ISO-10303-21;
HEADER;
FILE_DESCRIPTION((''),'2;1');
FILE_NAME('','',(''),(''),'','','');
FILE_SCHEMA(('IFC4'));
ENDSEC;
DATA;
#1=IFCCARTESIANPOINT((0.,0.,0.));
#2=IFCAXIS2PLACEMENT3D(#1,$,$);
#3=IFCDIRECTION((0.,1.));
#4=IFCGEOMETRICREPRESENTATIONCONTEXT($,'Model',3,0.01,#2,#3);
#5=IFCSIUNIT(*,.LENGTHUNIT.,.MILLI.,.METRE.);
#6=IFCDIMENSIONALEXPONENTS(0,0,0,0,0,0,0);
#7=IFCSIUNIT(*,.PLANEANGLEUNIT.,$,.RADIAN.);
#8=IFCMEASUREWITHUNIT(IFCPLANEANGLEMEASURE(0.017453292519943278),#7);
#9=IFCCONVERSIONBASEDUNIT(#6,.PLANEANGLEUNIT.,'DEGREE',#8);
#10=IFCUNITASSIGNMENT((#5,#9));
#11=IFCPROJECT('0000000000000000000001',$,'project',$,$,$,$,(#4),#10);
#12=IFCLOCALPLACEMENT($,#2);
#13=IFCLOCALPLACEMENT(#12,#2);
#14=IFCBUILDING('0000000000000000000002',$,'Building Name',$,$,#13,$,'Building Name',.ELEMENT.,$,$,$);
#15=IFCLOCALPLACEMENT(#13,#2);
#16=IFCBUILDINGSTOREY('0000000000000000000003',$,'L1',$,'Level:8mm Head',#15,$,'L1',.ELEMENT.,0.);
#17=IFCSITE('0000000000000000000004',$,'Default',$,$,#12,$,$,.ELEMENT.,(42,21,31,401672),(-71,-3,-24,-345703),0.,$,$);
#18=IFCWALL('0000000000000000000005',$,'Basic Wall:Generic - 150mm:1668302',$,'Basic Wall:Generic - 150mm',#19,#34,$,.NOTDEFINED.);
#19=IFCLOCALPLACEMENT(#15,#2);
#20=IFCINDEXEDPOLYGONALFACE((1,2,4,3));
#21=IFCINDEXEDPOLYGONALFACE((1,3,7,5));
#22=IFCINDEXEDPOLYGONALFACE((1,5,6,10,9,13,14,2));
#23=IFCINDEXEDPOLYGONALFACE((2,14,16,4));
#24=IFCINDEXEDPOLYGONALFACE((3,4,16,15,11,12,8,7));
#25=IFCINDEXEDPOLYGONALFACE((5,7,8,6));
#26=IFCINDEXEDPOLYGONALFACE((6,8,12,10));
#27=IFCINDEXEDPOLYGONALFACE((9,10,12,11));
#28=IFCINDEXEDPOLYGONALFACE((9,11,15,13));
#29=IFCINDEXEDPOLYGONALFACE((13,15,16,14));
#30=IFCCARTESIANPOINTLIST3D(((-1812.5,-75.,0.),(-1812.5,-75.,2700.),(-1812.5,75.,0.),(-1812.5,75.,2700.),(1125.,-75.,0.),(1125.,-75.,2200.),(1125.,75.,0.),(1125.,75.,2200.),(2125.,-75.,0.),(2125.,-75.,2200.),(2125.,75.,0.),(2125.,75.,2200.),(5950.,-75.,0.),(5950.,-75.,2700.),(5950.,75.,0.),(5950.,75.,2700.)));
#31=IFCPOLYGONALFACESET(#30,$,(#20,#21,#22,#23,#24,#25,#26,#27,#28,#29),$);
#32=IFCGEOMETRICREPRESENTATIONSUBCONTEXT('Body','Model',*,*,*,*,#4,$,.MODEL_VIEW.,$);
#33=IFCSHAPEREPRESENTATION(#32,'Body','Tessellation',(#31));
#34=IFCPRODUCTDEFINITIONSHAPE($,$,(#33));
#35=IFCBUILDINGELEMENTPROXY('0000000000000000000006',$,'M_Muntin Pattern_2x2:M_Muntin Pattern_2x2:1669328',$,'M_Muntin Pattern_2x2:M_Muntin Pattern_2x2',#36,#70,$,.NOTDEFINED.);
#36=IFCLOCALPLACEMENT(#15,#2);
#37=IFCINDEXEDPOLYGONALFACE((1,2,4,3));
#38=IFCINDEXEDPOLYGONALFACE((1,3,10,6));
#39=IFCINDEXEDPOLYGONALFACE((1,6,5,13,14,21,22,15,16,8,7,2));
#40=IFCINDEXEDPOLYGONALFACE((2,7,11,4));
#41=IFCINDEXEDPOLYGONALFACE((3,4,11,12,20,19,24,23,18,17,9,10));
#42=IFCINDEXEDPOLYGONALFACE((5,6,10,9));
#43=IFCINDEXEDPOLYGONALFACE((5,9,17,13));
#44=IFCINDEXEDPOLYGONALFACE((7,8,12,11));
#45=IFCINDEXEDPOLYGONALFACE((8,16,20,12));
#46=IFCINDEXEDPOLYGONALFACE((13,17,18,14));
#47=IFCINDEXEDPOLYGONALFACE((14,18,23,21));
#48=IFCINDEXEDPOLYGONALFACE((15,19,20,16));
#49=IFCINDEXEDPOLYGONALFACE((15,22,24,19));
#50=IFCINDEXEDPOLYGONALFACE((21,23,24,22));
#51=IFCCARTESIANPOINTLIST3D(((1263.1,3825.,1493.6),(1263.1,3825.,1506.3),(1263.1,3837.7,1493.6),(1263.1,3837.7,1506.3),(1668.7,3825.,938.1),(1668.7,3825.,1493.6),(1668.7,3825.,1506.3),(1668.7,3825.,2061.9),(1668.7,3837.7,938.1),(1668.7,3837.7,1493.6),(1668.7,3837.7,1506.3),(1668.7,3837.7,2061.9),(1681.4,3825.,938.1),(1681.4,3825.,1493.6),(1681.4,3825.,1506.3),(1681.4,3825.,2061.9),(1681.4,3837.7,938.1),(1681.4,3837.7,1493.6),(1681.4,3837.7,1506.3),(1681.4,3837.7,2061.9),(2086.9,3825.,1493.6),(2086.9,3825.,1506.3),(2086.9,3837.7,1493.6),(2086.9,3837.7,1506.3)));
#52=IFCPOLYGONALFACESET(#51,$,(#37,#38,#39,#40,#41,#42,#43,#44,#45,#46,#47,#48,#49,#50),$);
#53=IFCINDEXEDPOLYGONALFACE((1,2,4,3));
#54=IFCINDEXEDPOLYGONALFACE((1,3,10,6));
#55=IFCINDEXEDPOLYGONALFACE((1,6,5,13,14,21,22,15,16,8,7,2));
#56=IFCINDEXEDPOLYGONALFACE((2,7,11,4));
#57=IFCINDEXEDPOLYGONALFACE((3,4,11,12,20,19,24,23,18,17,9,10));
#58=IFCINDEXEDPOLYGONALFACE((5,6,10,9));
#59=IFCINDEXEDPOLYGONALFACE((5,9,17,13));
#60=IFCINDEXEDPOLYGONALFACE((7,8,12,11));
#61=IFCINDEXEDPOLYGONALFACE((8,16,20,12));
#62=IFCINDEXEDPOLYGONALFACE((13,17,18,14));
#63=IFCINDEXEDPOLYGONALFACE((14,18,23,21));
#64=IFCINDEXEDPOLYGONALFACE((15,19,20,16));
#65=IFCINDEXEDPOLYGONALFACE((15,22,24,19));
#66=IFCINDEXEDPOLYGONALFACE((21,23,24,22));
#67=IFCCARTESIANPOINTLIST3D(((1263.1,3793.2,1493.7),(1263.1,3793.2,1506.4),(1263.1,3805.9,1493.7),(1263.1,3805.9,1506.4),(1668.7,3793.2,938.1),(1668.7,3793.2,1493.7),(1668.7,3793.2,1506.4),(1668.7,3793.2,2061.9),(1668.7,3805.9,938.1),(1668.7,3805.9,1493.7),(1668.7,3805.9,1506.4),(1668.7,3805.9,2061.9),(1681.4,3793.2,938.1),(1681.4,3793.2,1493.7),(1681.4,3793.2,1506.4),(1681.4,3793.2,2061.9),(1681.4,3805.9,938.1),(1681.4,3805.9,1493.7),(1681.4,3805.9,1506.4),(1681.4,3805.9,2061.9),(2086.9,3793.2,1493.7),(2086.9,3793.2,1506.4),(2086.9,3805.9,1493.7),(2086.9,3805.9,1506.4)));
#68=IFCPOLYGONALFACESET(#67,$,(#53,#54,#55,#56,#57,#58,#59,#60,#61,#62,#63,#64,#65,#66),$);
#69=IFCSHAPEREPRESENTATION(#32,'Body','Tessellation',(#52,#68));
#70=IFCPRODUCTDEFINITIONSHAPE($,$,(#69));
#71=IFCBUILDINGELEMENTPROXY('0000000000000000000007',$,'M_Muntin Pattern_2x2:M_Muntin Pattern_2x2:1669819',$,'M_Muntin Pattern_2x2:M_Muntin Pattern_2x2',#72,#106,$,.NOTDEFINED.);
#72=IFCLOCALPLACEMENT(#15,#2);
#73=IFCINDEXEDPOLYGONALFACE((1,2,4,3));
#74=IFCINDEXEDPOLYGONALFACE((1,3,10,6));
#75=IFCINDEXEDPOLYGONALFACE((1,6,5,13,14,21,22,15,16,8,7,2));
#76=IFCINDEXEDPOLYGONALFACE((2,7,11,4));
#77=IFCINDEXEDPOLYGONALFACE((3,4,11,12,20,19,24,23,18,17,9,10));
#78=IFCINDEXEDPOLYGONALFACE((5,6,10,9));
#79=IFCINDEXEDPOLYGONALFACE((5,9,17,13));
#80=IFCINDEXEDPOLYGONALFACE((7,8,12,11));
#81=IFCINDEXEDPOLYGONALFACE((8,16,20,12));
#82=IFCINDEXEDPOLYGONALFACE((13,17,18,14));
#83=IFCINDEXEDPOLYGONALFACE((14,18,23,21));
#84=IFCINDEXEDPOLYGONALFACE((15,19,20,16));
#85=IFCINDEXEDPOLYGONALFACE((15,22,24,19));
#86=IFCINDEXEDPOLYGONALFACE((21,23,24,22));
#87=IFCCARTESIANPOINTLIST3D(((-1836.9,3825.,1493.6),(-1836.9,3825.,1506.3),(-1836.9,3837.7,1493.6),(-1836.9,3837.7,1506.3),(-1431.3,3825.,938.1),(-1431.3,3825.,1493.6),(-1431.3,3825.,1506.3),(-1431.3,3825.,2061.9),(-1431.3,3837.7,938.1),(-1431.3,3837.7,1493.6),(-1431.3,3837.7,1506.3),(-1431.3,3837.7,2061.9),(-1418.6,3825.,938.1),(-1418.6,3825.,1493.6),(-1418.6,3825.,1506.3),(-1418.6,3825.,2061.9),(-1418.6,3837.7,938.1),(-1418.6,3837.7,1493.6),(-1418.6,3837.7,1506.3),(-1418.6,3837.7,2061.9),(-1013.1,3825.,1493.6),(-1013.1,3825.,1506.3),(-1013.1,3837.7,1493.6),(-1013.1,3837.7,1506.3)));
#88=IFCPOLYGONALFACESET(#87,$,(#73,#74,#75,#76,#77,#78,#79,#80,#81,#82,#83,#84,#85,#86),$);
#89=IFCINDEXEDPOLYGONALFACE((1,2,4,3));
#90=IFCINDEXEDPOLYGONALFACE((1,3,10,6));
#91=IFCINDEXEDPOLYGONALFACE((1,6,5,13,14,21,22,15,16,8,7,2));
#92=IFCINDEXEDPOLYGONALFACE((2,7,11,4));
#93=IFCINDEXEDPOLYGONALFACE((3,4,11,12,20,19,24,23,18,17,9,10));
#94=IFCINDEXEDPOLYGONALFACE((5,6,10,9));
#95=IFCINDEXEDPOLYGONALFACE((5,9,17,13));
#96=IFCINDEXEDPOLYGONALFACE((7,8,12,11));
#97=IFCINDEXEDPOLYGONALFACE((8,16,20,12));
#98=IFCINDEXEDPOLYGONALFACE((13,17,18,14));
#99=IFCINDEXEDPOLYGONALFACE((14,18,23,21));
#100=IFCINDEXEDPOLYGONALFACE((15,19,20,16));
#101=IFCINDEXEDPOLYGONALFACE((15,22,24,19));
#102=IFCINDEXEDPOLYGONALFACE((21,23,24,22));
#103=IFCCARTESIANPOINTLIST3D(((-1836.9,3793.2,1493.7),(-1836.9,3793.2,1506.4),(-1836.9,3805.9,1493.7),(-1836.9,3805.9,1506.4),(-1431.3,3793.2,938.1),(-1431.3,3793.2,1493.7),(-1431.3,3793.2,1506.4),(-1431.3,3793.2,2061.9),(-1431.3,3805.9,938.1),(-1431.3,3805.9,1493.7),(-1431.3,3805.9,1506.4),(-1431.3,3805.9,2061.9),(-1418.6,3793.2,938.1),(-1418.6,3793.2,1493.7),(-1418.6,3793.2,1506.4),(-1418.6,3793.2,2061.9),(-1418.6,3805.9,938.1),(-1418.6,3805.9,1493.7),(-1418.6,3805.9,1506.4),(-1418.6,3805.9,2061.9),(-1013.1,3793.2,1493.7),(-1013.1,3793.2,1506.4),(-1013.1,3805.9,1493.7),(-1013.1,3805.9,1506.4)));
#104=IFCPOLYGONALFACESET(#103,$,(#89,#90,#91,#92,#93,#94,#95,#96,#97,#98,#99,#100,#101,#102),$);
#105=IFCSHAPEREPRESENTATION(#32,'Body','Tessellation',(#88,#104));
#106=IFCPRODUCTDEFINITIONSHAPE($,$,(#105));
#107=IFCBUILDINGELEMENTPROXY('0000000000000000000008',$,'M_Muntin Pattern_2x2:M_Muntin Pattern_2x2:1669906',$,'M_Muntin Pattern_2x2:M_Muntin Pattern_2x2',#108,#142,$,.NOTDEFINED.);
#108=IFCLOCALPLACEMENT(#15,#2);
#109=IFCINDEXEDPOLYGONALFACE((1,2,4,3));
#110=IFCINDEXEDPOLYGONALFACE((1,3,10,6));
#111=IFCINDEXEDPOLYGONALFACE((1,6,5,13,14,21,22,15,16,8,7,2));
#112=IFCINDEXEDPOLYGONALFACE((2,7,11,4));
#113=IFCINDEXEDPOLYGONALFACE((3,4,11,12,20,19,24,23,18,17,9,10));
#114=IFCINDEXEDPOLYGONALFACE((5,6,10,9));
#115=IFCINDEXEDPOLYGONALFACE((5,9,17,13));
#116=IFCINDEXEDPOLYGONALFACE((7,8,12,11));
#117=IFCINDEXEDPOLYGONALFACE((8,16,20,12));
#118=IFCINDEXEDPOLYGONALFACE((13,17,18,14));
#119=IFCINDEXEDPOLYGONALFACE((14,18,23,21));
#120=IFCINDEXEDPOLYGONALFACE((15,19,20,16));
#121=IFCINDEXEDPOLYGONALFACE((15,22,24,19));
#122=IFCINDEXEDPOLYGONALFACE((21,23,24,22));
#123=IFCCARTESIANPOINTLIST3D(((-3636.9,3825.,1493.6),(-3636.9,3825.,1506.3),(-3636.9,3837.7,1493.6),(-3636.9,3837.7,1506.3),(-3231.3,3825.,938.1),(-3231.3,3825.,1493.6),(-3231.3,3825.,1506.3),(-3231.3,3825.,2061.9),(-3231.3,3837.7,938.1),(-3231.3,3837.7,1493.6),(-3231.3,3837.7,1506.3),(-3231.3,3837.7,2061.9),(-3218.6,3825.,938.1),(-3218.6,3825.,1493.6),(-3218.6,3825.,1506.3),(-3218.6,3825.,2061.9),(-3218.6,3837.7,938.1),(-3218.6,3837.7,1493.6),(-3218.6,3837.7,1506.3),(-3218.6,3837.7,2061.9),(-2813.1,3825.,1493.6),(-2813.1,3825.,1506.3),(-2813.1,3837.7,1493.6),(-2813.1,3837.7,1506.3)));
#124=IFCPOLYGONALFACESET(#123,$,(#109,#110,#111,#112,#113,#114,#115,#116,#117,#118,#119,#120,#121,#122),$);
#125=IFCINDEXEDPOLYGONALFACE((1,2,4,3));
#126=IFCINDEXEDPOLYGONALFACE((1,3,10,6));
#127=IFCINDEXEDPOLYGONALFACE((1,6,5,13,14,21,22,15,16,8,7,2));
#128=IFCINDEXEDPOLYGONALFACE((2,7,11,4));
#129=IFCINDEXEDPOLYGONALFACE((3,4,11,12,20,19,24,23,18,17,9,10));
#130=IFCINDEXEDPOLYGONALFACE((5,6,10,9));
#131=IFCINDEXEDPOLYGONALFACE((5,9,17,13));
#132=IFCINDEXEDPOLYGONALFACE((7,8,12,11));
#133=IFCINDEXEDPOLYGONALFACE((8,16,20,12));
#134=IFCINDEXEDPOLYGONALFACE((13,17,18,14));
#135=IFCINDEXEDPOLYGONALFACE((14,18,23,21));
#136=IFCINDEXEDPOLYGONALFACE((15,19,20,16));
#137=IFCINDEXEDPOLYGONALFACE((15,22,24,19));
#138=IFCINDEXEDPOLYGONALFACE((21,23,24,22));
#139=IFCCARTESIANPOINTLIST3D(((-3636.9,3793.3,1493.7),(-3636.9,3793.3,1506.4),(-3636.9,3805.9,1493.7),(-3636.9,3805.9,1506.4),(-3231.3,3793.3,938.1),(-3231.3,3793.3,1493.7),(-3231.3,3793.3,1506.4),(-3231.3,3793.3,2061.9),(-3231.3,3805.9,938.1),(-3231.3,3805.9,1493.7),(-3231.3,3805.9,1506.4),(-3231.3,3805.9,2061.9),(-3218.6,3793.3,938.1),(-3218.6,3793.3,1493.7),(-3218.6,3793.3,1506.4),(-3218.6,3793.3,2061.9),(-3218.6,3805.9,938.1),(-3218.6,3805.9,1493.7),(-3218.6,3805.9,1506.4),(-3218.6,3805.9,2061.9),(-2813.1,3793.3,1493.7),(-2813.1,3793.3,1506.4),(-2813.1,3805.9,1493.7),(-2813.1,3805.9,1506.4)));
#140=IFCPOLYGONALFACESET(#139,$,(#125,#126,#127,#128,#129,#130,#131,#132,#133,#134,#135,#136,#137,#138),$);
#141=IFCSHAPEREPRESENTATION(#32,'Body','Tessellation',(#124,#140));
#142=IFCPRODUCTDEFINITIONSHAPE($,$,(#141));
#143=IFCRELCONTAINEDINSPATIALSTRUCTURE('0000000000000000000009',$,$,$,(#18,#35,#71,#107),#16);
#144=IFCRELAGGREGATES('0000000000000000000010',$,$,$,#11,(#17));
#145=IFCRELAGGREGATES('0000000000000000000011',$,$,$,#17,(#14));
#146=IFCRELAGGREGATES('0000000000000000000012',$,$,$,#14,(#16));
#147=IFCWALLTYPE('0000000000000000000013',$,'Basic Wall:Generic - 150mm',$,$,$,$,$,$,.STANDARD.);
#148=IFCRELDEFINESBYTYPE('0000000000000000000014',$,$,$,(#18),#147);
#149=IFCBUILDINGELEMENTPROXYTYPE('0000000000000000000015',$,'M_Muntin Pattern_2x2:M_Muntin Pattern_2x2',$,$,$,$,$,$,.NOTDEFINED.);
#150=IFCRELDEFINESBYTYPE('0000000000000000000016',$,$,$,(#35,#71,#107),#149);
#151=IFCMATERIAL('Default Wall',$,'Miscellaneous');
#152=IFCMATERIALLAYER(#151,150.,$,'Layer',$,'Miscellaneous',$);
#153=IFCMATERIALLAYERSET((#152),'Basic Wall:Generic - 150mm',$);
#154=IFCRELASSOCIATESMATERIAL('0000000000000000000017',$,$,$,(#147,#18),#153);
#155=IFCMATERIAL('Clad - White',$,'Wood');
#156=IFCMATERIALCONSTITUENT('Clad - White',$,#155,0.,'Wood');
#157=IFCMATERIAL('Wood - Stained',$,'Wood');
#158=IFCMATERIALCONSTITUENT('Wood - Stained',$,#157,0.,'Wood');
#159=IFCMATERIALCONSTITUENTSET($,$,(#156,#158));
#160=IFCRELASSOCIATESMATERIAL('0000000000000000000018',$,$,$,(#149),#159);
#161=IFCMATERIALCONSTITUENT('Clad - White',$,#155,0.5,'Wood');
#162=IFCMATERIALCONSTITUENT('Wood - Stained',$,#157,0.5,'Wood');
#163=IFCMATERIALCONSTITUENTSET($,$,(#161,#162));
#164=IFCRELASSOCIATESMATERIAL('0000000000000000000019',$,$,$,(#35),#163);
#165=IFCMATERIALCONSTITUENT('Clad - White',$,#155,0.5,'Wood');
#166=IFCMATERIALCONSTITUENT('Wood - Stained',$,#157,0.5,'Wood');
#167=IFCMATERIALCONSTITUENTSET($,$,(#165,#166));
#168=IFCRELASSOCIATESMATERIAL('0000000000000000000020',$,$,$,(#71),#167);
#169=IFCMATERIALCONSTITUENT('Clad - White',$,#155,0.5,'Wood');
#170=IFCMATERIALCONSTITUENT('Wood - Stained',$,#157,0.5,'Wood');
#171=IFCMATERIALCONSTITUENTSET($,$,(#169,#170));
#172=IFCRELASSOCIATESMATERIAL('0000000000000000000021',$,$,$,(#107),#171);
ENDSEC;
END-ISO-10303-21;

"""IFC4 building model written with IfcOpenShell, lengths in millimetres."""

from ifc_helpers import new_model, entity, si_unit, converted_unit, direction, frame, frame_2d, origin, origin_2d_with_axis, place, context, subcontext, project, spatial, polyline, rectangle, outline, extrude, source, transform, mapped, material, layer, layer_set, layer_usage, constituent, constituent_set, type_object, type_shapes, element, save


model = new_model("IFC4")

# Units and contexts
model_context = context("Model", 3, precision=0.01, world=origin(), true_north=direction((0.0, 1.0)))
body_context = subcontext(model_context, "Body", "Model", "MODEL_VIEW")
ifc_project = project(units=[si_unit("LENGTHUNIT", "METRE", prefix="MILLI"), converted_unit("PLANEANGLEUNIT", "DEGREE", entity("IfcPlaneAngleMeasure", 0.017453292519943278), si_unit("PLANEANGLEUNIT", "RADIAN"), dimensions=[0, 0, 0, 0, 0, 0, 0])], contexts=[model_context])

# Site, building, storey
site_placement = place(None, origin())
site = spatial("IfcSite", under=ifc_project, at=site_placement, Name="Default", CompositionType="ELEMENT", RefLatitude=(42, 21, 31, 401672), RefLongitude=(-71, -3, -24, -345703), RefElevation=0.0)
building_placement = place(site_placement, origin())
building = spatial("IfcBuilding", under=site, at=building_placement, Name="Building Name", LongName="Building Name", CompositionType="ELEMENT")
storey_placement = place(building_placement, origin())
storey = spatial("IfcBuildingStorey", under=building, at=storey_placement, Name="L1", ObjectType="Level:8mm Head", LongName="L1", CompositionType="ELEMENT", Elevation=0.0)

# Shared definitions
ifc_material_1 = material(Name="Default Wall", Category="Miscellaneous")
ifc_layer_1 = layer(ifc_material_1, 150.0, Name="Layer", Category="Miscellaneous")
ifc_layer_set_1 = layer_set([ifc_layer_1], Name="Basic Wall:Generic - 150mm")
wall_type = type_object("IfcWallType", Name="Basic Wall:Generic - 150mm", PredefinedType="STANDARD", material=ifc_layer_set_1)

# Wall, openings
ifc_layer_usage_1 = layer_usage(ifc_layer_set_1, "AXIS2", "NEGATIVE", 75.0)
wall_1_placement = place(storey_placement, frame((5950.0, 0.0, 0.0), z_axis=(0.0, 0.0, 1.0), x_axis=(-1.0, 0.0, 0.0)))
wall_1 = element("IfcWall", 1, at=wall_1_placement, inside=storey, type_object=wall_type, material=ifc_layer_usage_1, Name="Basic Wall:Generic - 150mm:1668302", ObjectType="Basic Wall:Generic - 150mm", PredefinedType="NOTDEFINED", context=body_context, shape_type="SweptSolid", body=[
    extrude(rectangle(XDim=7762.5, YDim=150.0, at=frame_2d((3881.2, 0.0), x_axis=(1.0, 0.0))), origin(), (0.0, 0.0, 1.0), 2700.0),
])
opening_1_placement = place(wall_1_placement, frame((4825.0, 75.0, 0.0)))
element("IfcOpeningElement", 2, at=opening_1_placement, cuts=wall_1, PredefinedType="OPENING", context=body_context, shape_type="SweptSolid", body=[
    extrude(rectangle(XDim=2200.0, YDim=1000.0, at=frame_2d((1100.0, 500.0), x_axis=(1.0, 0.0))), frame((0.0, 0.0, 0.0), z_axis=(0.0, -1.0, 0.0), x_axis=(0.0, 0.0, 1.0)), (0.0, 0.0, 1.0), 150.0),
])
opening_2_placement = place(wall_1_placement, frame((5950.0, 0.0, 0.0), z_axis=(0.0, 0.0, 1.0), x_axis=(-1.0, 0.0, 0.0)))
element("IfcOpeningElement", 3, at=opening_2_placement, cuts=wall_1, PredefinedType="OPENING", context=body_context, shape_type="SweptSolid", body=[
    extrude(rectangle(XDim=2200.0, YDim=1000.0, at=origin_2d_with_axis()), frame((1625.0, 1449.0, 1100.0), z_axis=(0.0, -1.0, 0.0), x_axis=(0.0, 0.0, 1.0)), (0.0, 0.0, 1.0), 3048.0),
])

# Building element proxies
ifc_material_2 = material(Name="Clad - White", Category="Wood")
ifc_constituent_1 = constituent(ifc_material_2, Name="Clad - White", Category="Wood", fraction=0.5)
ifc_material_3 = material(Name="Wood - Stained", Category="Wood")
ifc_constituent_2 = constituent(ifc_material_3, Name="Wood - Stained", Category="Wood", fraction=0.5)
ifc_constituent_set_1 = constituent_set(constituents=[ifc_constituent_1, ifc_constituent_2])
ifc_constituent_3 = constituent(ifc_material_2, Name="Clad - White", Category="Wood", fraction=0.0)
ifc_constituent_4 = constituent(ifc_material_3, Name="Wood - Stained", Category="Wood", fraction=0.0)
ifc_constituent_set_2 = constituent_set(constituents=[ifc_constituent_3, ifc_constituent_4])
building_element_proxy_type_1 = type_object("IfcBuildingElementProxyType", Name="M_Muntin Pattern_2x2:M_Muntin Pattern_2x2", PredefinedType="NOTDEFINED", material=ifc_constituent_set_2)
shared_shape_1 = source(origin(), body_context, "Body", "SweptSolid", [
    extrude(outline(polyline([(6.4, -6.4), (561.9, -6.4), (561.9, 6.3), (6.4, 6.3), (6.4, 411.9), (-6.3, 411.9), (-6.3, 6.3), (-561.9, 6.3), (-561.9, -6.4), (-6.3, -6.4), (-6.3, -411.9), (6.4, -411.9), (6.4, -6.4)])), frame((0.0, -22.2, 561.9), z_axis=(0.0, 1.0, 0.0), x_axis=(0.0, 0.0, 1.0)), (0.0, 0.0, 1.0), 12.7),
    extrude(outline(polyline([(6.4, -6.4), (561.9, -6.4), (561.9, 6.3), (6.4, 6.3), (6.4, 411.9), (-6.3, 411.9), (-6.3, 6.3), (-561.9, 6.3), (-561.9, -6.4), (-6.3, -6.4), (-6.3, -411.9), (6.4, -411.9), (6.4, -6.4)])), frame((0.0, 9.5, 561.9), z_axis=(0.0, 1.0, 0.0), x_axis=(0.0, 0.0, 1.0)), (0.0, 0.0, 1.0), 12.7),
])
type_shapes(building_element_proxy_type_1, [shared_shape_1])
proxy_1_placement = place(storey_placement, frame((1675.0, 3815.5, 938.1), z_axis=(0.0, 0.0, 1.0), x_axis=(-1.0, 0.0, 0.0)))
element("IfcBuildingElementProxy", 4, at=proxy_1_placement, inside=storey, type_object=building_element_proxy_type_1, material=ifc_constituent_set_1, Name="M_Muntin Pattern_2x2:M_Muntin Pattern_2x2:1669328", ObjectType="M_Muntin Pattern_2x2:M_Muntin Pattern_2x2", PredefinedType="NOTDEFINED", context=body_context, shape_type="MappedRepresentation", body=[
    mapped(shared_shape_1, transform((0.0, 0.0, 0.0), scale=1.0)),
])
ifc_constituent_5 = constituent(ifc_material_2, Name="Clad - White", Category="Wood", fraction=0.5)
ifc_constituent_6 = constituent(ifc_material_3, Name="Wood - Stained", Category="Wood", fraction=0.5)
ifc_constituent_set_3 = constituent_set(constituents=[ifc_constituent_5, ifc_constituent_6])
proxy_2_placement = place(storey_placement, frame((-1425.0, 3815.5, 938.1), z_axis=(0.0, 0.0, 1.0), x_axis=(-1.0, 0.0, 0.0)))
element("IfcBuildingElementProxy", 5, at=proxy_2_placement, inside=storey, type_object=building_element_proxy_type_1, material=ifc_constituent_set_3, Name="M_Muntin Pattern_2x2:M_Muntin Pattern_2x2:1669819", ObjectType="M_Muntin Pattern_2x2:M_Muntin Pattern_2x2", PredefinedType="NOTDEFINED", context=body_context, shape_type="MappedRepresentation", body=[
    mapped(shared_shape_1, transform((0.0, 0.0, 0.0), scale=1.0)),
])
ifc_constituent_7 = constituent(ifc_material_2, Name="Clad - White", Category="Wood", fraction=0.5)
ifc_constituent_8 = constituent(ifc_material_3, Name="Wood - Stained", Category="Wood", fraction=0.5)
ifc_constituent_set_4 = constituent_set(constituents=[ifc_constituent_7, ifc_constituent_8])
proxy_3_placement = place(storey_placement, frame((-3225.0, 3815.5, 938.1), z_axis=(0.0, 0.0, 1.0), x_axis=(-1.0, 0.0, 0.0)))
element("IfcBuildingElementProxy", 6, at=proxy_3_placement, inside=storey, type_object=building_element_proxy_type_1, material=ifc_constituent_set_4, Name="M_Muntin Pattern_2x2:M_Muntin Pattern_2x2:1669906", ObjectType="M_Muntin Pattern_2x2:M_Muntin Pattern_2x2", PredefinedType="NOTDEFINED", context=body_context, shape_type="MappedRepresentation", body=[
    mapped(shared_shape_1, transform((0.0, 0.0, 0.0), scale=1.0)),
])

save(model, "model.ifc")
